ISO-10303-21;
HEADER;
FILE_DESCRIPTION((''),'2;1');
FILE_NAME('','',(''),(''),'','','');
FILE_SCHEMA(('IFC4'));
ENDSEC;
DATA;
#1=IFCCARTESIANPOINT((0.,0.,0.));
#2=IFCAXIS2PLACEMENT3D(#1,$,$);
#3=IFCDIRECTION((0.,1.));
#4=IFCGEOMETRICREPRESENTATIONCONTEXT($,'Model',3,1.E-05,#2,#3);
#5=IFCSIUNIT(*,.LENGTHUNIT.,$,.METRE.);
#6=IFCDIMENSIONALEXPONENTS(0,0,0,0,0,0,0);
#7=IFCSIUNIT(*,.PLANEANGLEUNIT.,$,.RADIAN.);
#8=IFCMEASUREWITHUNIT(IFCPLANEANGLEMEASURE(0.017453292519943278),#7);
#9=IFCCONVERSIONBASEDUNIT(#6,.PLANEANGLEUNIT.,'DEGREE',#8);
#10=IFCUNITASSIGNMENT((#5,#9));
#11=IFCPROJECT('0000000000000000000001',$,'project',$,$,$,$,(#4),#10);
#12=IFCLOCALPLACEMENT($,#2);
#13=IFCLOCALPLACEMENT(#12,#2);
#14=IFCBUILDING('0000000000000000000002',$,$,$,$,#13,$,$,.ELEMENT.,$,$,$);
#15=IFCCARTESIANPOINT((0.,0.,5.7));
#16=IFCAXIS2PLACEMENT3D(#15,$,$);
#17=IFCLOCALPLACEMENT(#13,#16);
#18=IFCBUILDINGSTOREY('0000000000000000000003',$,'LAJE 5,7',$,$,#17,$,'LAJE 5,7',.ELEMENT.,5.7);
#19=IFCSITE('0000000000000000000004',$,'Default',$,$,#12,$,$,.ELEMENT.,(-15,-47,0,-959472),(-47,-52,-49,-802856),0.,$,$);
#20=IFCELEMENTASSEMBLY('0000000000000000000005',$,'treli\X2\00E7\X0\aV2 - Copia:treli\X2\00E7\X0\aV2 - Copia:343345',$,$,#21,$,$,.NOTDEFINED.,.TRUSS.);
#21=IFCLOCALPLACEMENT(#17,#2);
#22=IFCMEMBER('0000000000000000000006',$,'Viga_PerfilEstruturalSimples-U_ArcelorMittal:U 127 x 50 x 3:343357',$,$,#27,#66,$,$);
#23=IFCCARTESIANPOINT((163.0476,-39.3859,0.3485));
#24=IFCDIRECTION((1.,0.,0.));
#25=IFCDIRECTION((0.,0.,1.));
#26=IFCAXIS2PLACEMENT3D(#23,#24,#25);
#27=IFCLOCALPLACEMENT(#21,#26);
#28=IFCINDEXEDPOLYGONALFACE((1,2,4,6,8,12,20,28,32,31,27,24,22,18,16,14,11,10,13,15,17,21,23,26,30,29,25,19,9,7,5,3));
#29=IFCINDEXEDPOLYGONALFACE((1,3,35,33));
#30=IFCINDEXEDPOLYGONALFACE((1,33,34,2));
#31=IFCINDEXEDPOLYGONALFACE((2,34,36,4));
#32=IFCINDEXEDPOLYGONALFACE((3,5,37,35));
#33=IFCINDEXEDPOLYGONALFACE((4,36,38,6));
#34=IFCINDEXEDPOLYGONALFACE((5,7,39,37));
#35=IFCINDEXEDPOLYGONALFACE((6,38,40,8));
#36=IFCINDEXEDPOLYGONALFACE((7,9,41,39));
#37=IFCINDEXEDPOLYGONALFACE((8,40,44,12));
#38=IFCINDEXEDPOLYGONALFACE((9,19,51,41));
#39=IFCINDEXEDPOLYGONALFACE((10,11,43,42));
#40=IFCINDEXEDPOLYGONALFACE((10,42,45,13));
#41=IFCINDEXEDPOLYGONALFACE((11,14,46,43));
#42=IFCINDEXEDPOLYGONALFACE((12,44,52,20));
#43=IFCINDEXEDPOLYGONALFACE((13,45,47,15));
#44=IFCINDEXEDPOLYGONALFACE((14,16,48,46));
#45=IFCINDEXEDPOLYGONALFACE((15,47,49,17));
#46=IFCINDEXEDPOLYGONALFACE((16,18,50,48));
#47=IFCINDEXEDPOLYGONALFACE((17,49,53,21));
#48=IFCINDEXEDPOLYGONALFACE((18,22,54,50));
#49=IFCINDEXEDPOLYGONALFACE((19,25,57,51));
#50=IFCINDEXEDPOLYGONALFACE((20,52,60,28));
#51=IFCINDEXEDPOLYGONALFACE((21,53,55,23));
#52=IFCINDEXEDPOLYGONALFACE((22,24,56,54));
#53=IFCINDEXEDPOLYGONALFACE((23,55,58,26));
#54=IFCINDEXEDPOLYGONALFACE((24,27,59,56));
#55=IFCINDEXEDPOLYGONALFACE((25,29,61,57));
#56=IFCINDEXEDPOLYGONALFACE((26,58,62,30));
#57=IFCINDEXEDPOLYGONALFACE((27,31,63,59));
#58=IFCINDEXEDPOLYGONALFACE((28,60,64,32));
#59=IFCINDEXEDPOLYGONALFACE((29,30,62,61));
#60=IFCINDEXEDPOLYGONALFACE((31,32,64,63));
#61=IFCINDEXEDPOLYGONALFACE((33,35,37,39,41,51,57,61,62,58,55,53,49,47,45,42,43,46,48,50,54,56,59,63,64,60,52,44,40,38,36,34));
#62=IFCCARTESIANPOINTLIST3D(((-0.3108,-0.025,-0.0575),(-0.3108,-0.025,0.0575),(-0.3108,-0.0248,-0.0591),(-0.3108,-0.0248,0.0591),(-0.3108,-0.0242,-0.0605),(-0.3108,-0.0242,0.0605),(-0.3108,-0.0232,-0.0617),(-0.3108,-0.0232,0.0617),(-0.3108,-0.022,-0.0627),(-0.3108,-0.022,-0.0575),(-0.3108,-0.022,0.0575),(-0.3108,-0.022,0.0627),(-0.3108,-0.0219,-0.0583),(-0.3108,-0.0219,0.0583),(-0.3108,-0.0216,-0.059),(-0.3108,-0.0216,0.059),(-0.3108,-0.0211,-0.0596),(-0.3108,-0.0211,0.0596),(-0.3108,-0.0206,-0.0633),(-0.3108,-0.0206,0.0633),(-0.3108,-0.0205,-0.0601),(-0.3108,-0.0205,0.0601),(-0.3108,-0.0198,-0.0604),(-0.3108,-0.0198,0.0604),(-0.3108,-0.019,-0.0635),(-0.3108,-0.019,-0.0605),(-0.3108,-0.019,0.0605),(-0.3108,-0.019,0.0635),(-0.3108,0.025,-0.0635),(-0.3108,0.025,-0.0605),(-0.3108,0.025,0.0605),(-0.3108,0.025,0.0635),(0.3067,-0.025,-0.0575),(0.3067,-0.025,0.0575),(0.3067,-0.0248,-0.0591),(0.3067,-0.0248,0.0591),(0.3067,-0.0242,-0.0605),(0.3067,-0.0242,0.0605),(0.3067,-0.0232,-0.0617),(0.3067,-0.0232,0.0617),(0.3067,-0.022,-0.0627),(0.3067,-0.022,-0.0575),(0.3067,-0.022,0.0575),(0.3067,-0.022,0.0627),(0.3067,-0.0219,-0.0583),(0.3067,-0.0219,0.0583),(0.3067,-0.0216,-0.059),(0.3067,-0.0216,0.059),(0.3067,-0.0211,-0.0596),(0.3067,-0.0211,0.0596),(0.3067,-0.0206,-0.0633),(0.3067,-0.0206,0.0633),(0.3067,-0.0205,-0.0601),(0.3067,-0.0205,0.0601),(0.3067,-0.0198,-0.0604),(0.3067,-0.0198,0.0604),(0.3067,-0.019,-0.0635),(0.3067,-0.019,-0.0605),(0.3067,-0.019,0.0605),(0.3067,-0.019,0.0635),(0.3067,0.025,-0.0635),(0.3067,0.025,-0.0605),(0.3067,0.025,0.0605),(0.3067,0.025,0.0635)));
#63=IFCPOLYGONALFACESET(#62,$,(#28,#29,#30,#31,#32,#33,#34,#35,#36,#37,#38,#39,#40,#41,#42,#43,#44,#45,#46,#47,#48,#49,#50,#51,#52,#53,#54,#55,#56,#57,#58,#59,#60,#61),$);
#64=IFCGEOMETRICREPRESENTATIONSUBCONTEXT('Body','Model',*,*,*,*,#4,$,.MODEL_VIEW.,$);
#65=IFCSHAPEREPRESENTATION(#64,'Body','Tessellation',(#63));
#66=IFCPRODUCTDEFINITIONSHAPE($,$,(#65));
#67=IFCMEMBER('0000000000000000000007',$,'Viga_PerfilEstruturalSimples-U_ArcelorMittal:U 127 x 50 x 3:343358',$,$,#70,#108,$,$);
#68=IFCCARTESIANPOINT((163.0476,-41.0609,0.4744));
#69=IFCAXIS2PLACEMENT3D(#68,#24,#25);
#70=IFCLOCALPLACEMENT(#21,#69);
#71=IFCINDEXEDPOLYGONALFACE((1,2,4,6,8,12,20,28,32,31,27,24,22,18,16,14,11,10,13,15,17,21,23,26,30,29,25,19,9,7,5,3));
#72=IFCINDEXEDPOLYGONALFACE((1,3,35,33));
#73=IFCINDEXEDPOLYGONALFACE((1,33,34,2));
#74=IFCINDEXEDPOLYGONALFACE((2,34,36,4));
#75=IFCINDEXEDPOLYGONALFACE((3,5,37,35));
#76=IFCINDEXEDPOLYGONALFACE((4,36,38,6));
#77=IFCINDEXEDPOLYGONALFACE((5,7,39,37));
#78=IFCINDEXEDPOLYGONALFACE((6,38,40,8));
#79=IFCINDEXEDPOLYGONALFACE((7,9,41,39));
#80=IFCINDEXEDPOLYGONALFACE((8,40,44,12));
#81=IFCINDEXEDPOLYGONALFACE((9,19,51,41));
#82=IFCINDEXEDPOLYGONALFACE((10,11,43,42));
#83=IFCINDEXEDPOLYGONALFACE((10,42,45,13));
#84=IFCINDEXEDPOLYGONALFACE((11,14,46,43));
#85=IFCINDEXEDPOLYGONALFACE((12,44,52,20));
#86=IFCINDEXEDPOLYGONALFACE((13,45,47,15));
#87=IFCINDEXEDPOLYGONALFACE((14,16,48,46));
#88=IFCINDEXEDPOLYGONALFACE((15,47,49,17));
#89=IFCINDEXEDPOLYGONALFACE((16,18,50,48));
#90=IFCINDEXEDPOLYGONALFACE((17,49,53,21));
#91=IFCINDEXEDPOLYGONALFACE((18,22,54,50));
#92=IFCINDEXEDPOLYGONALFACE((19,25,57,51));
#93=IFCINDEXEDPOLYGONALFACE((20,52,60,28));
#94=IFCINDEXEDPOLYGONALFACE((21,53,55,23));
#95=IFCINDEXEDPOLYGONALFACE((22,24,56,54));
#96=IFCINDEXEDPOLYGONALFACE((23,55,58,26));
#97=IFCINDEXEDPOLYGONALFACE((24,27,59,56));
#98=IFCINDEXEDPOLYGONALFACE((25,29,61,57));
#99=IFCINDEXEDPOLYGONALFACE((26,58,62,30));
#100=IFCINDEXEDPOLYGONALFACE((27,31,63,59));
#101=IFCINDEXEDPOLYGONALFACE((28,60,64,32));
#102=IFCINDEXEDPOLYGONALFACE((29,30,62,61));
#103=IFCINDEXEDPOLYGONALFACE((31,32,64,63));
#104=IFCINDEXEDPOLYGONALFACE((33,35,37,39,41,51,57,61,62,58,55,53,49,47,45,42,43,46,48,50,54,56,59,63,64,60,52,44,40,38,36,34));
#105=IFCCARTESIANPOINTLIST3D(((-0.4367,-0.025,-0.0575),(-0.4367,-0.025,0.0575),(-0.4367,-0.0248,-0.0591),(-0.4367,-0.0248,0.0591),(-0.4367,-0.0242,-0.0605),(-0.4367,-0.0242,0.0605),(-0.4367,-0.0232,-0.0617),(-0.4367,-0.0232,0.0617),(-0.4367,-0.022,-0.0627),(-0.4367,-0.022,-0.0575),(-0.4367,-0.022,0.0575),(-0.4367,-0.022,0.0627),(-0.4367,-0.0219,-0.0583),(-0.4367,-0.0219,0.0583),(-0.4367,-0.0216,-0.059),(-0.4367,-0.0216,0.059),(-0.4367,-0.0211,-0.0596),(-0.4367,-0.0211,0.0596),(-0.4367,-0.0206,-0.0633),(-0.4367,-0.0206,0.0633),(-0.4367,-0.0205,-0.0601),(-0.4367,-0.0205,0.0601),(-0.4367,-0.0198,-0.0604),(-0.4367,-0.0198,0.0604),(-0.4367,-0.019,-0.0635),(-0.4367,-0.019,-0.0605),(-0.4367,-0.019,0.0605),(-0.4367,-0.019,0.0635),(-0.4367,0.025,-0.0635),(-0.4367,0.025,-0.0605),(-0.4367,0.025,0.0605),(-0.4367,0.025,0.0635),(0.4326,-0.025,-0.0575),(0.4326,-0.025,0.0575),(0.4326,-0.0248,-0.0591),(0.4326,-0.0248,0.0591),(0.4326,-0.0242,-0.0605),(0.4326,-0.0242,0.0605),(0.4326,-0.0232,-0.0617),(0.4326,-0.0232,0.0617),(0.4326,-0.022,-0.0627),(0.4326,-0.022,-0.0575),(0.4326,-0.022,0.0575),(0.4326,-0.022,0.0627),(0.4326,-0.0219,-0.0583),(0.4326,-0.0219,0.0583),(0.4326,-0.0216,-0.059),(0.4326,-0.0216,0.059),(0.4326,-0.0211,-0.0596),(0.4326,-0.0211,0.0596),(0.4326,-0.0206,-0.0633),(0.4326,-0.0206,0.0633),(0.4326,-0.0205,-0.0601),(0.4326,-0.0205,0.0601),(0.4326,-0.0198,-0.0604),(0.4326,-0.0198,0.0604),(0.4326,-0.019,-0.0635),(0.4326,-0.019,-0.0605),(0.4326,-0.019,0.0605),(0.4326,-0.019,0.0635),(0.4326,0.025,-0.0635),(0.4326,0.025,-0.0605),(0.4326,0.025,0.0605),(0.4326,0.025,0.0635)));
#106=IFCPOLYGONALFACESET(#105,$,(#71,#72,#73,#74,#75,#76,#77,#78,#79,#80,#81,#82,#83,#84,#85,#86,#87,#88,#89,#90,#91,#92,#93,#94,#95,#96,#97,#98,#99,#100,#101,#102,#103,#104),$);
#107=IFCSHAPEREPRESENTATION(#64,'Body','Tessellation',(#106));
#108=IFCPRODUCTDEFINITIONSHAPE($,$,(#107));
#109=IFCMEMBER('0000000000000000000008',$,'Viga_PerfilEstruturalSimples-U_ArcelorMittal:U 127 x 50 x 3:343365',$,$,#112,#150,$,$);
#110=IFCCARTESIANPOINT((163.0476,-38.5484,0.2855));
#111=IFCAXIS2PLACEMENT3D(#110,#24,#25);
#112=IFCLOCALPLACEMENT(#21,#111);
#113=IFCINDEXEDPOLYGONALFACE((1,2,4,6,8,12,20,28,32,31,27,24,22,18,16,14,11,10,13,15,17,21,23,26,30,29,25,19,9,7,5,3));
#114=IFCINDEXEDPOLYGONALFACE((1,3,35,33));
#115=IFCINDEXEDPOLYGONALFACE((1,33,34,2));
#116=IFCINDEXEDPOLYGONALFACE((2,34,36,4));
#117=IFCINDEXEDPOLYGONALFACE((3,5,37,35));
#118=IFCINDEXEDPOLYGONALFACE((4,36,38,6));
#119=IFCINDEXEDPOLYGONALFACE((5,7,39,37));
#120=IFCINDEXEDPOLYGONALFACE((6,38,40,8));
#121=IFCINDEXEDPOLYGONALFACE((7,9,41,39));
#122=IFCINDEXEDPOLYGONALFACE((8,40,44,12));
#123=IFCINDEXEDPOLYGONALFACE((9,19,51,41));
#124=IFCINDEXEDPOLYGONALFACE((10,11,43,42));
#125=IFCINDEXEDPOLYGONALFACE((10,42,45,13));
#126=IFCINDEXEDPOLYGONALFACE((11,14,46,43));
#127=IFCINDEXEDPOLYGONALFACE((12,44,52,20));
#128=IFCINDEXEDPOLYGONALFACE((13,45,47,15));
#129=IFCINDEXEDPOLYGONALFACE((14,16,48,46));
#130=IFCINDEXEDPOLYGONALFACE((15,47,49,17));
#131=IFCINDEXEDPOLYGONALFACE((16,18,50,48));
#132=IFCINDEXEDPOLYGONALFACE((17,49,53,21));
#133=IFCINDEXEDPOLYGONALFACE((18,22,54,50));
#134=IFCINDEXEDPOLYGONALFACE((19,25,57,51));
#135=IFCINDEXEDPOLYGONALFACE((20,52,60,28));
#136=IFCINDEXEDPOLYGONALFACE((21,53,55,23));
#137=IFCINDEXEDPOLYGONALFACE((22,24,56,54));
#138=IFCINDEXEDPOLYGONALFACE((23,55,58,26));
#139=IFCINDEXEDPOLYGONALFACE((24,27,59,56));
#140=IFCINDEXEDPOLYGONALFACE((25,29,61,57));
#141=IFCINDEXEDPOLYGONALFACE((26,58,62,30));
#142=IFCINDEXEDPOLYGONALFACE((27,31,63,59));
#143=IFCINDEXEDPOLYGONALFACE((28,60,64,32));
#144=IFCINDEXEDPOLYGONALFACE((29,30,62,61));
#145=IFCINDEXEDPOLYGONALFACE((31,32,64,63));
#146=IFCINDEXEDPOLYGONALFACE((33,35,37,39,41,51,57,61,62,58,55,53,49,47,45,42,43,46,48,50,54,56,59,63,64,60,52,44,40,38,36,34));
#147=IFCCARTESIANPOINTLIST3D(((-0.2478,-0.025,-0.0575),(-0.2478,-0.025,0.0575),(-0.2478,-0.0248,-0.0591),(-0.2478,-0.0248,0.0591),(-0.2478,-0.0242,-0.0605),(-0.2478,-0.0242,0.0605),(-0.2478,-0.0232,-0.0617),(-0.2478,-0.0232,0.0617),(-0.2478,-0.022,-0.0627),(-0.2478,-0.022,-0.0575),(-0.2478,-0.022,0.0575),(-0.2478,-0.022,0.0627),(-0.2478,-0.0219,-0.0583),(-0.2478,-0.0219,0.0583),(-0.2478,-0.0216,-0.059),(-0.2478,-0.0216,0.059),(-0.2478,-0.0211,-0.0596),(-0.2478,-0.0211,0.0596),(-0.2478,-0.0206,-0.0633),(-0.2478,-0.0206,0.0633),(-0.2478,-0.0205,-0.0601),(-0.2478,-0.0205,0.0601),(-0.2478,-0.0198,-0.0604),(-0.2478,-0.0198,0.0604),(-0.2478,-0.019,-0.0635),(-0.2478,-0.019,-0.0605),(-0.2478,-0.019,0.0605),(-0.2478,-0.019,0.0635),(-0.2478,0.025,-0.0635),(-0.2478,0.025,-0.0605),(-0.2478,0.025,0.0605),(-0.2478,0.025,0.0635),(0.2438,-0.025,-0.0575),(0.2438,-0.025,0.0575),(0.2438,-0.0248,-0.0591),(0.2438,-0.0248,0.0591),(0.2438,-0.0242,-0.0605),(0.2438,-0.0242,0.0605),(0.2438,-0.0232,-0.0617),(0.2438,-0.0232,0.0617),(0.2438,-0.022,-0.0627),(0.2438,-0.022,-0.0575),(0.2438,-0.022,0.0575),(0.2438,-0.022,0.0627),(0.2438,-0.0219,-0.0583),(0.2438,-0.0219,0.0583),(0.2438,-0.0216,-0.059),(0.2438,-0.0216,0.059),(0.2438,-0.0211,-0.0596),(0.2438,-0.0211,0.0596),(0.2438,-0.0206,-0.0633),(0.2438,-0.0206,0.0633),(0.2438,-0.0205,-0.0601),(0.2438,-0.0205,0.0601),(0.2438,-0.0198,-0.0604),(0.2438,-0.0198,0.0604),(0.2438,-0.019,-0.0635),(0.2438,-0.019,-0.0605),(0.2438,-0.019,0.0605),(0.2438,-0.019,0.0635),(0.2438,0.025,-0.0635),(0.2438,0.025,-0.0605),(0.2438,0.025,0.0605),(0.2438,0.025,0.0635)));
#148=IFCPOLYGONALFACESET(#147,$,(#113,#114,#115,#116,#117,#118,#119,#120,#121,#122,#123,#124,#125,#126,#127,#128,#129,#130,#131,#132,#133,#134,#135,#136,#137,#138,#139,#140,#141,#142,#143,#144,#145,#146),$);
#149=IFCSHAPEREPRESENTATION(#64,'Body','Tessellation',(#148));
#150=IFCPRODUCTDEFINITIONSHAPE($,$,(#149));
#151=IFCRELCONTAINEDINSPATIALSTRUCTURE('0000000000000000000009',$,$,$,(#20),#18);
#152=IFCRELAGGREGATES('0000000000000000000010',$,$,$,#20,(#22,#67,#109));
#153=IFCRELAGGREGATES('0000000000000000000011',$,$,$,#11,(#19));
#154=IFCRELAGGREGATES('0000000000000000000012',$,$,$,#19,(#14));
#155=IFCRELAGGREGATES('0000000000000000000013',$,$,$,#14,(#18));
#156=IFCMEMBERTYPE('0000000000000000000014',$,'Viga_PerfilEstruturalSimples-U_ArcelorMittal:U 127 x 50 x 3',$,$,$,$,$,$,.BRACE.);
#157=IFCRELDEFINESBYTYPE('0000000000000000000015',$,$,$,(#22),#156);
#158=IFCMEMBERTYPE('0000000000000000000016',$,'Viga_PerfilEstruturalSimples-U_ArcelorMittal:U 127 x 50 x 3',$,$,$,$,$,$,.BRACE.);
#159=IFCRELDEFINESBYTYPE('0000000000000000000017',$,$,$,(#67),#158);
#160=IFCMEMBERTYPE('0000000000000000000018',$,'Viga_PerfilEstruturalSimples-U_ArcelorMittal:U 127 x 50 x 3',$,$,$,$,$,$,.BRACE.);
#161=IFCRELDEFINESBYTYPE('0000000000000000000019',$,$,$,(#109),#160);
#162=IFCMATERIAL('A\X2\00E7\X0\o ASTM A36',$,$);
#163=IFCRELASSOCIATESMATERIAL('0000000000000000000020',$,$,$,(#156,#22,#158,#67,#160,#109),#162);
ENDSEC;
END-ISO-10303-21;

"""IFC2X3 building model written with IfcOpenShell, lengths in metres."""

from ifc_helpers import new_model, entity, si_unit, converted_unit, direction, frame, frame_2d, origin, place, context, subcontext, project, spatial, polyline, circle_curve, parameter, trimmed, segment, composite_curve, outline, extrude, source, transform, mapped, material, type_object, type_shapes, element, aggregate, save


model = new_model("IFC2X3")

# Units and contexts
model_context = context("Model", 3, precision=1e-05, world=origin(), true_north=direction((0.0, 1.0)))
body_context = subcontext(model_context, "Body", "Model", "MODEL_VIEW")
ifc_project = project(units=[si_unit("LENGTHUNIT", "METRE"), converted_unit("PLANEANGLEUNIT", "DEGREE", entity("IfcPlaneAngleMeasure", 0.017453292519943278), si_unit("PLANEANGLEUNIT", "RADIAN"), dimensions=[0, 0, 0, 0, 0, 0, 0])], contexts=[model_context])

# Site, building, storey
site_placement = place(None, origin())
site = spatial("IfcSite", under=ifc_project, at=site_placement, Name="Default", CompositionType="ELEMENT", RefLatitude=(-15, -47, 0, -959472), RefLongitude=(-47, -52, -49, -802856), RefElevation=0.0)
building_placement = place(site_placement, origin())
building = spatial("IfcBuilding", under=site, at=building_placement, CompositionType="ELEMENT")
storey_placement = place(building_placement, frame((0.0, 0.0, 5.7)))
storey = spatial("IfcBuildingStorey", under=building, at=storey_placement, Name="LAJE 5,7", LongName="LAJE 5,7", CompositionType="ELEMENT", Elevation=5.7)

# Element assembly
assembly_1_placement = place(storey_placement, origin())
assembly_1 = element("IfcElementAssembly", 1, at=assembly_1_placement, inside=storey, Name="treliçaV2 - Copia:treliçaV2 - Copia:343345", AssemblyPlace="NOTDEFINED", PredefinedType="TRUSS")
ifc_material = material(Name="Aço ASTM A36")

# Members
member_type_1 = type_object("IfcMemberType", Name="Viga_PerfilEstruturalSimples-U_ArcelorMittal:U 127 x 50 x 3", PredefinedType="BRACE", material=ifc_material)
shared_shape_1 = source(origin(), body_context, "Body", "SweptSolid", [
    extrude(outline(composite_curve([segment(polyline([(-0.0575, -0.0192), (0.0575, -0.0192)]), True, "CONTINUOUS"), segment(trimmed(circle_curve(frame_2d((0.0575, -0.0132), x_axis=(0.0, 1.0)), 0.006), [parameter(180.0)], [parameter(270.0)], True, "PARAMETER"), True, "CONTINUOUS"), segment(polyline([(0.0635, -0.0132), (0.0635, 0.0308)]), True, "CONTINUOUS"), segment(polyline([(0.0635, 0.0308), (0.0605, 0.0308)]), True, "CONTINUOUS"), segment(polyline([(0.0605, 0.0308), (0.0605, -0.0132)]), True, "CONTINUOUS"), segment(trimmed(circle_curve(frame_2d((0.0575, -0.0132), x_axis=(0.0, 1.0)), 0.003), [parameter(180.0)], [parameter(270.0)], True, "PARAMETER"), False, "CONTINUOUS"), segment(polyline([(0.0575, -0.0162), (-0.0575, -0.0162)]), True, "CONTINUOUS"), segment(trimmed(circle_curve(frame_2d((-0.0575, -0.0132), x_axis=(0.0, 1.0)), 0.003), [parameter(90.0)], [parameter(180.0)], True, "PARAMETER"), False, "CONTINUOUS"), segment(polyline([(-0.0605, -0.0132), (-0.0605, 0.0308)]), True, "CONTINUOUS"), segment(polyline([(-0.0605, 0.0308), (-0.0635, 0.0308)]), True, "CONTINUOUS"), segment(polyline([(-0.0635, 0.0308), (-0.0635, -0.0132)]), True, "CONTINUOUS"), segment(trimmed(circle_curve(frame_2d((-0.0575, -0.0132), x_axis=(0.0, 1.0)), 0.006), [parameter(90.0)], [parameter(180.0)], True, "PARAMETER"), True, "CONTINUOUS")], self_intersect=False)), frame((-0.3108, -0.0058, 0.0), z_axis=(1.0, 0.0, 0.0), x_axis=(0.0, 0.0, -1.0)), (0.0, 0.0, 1.0), 0.6175),
])
type_shapes(member_type_1, [shared_shape_1])
member_1_placement = place(assembly_1_placement, frame((163.0476, -39.3859, 0.3485), z_axis=(1.0, 0.0, 0.0), x_axis=(0.0, 0.0, 1.0)))
member_1 = element("IfcMember", 2, at=member_1_placement, type_object=member_type_1, material=ifc_material, Name="Viga_PerfilEstruturalSimples-U_ArcelorMittal:U 127 x 50 x 3:343357", context=body_context, shape_type="MappedRepresentation", body=[
    mapped(shared_shape_1, transform((0.0, 0.0, 0.0), scale=1.0)),
])
member_type_2 = type_object("IfcMemberType", Name="Viga_PerfilEstruturalSimples-U_ArcelorMittal:U 127 x 50 x 3", PredefinedType="BRACE", material=ifc_material)
shared_shape_2 = source(origin(), body_context, "Body", "SweptSolid", [
    extrude(outline(composite_curve([segment(polyline([(-0.0575, -0.0192), (0.0575, -0.0192)]), True, "CONTINUOUS"), segment(trimmed(circle_curve(frame_2d((0.0575, -0.0132), x_axis=(0.0, 1.0)), 0.006), [parameter(180.0)], [parameter(270.0)], True, "PARAMETER"), True, "CONTINUOUS"), segment(polyline([(0.0635, -0.0132), (0.0635, 0.0308)]), True, "CONTINUOUS"), segment(polyline([(0.0635, 0.0308), (0.0605, 0.0308)]), True, "CONTINUOUS"), segment(polyline([(0.0605, 0.0308), (0.0605, -0.0132)]), True, "CONTINUOUS"), segment(trimmed(circle_curve(frame_2d((0.0575, -0.0132), x_axis=(0.0, 1.0)), 0.003), [parameter(180.0)], [parameter(270.0)], True, "PARAMETER"), False, "CONTINUOUS"), segment(polyline([(0.0575, -0.0162), (-0.0575, -0.0162)]), True, "CONTINUOUS"), segment(trimmed(circle_curve(frame_2d((-0.0575, -0.0132), x_axis=(0.0, 1.0)), 0.003), [parameter(90.0)], [parameter(180.0)], True, "PARAMETER"), False, "CONTINUOUS"), segment(polyline([(-0.0605, -0.0132), (-0.0605, 0.0308)]), True, "CONTINUOUS"), segment(polyline([(-0.0605, 0.0308), (-0.0635, 0.0308)]), True, "CONTINUOUS"), segment(polyline([(-0.0635, 0.0308), (-0.0635, -0.0132)]), True, "CONTINUOUS"), segment(trimmed(circle_curve(frame_2d((-0.0575, -0.0132), x_axis=(0.0, 1.0)), 0.006), [parameter(90.0)], [parameter(180.0)], True, "PARAMETER"), True, "CONTINUOUS")], self_intersect=False)), frame((-0.4367, -0.0058, 0.0), z_axis=(1.0, 0.0, 0.0), x_axis=(0.0, 0.0, -1.0)), (0.0, 0.0, 1.0), 0.8693),
])
type_shapes(member_type_2, [shared_shape_2])
member_2_placement = place(assembly_1_placement, frame((163.0476, -41.0609, 0.4744), z_axis=(1.0, 0.0, 0.0), x_axis=(0.0, 0.0, 1.0)))
member_2 = element("IfcMember", 3, at=member_2_placement, type_object=member_type_2, material=ifc_material, Name="Viga_PerfilEstruturalSimples-U_ArcelorMittal:U 127 x 50 x 3:343358", context=body_context, shape_type="MappedRepresentation", body=[
    mapped(shared_shape_2, transform((0.0, 0.0, 0.0), scale=1.0)),
])
member_type_3 = type_object("IfcMemberType", Name="Viga_PerfilEstruturalSimples-U_ArcelorMittal:U 127 x 50 x 3", PredefinedType="BRACE", material=ifc_material)
shared_shape_3 = source(origin(), body_context, "Body", "SweptSolid", [
    extrude(outline(composite_curve([segment(polyline([(-0.0575, -0.0192), (0.0575, -0.0192)]), True, "CONTINUOUS"), segment(trimmed(circle_curve(frame_2d((0.0575, -0.0132), x_axis=(0.0, 1.0)), 0.006), [parameter(180.0)], [parameter(270.0)], True, "PARAMETER"), True, "CONTINUOUS"), segment(polyline([(0.0635, -0.0132), (0.0635, 0.0308)]), True, "CONTINUOUS"), segment(polyline([(0.0635, 0.0308), (0.0605, 0.0308)]), True, "CONTINUOUS"), segment(polyline([(0.0605, 0.0308), (0.0605, -0.0132)]), True, "CONTINUOUS"), segment(trimmed(circle_curve(frame_2d((0.0575, -0.0132), x_axis=(0.0, 1.0)), 0.003), [parameter(180.0)], [parameter(270.0)], True, "PARAMETER"), False, "CONTINUOUS"), segment(polyline([(0.0575, -0.0162), (-0.0575, -0.0162)]), True, "CONTINUOUS"), segment(trimmed(circle_curve(frame_2d((-0.0575, -0.0132), x_axis=(0.0, 1.0)), 0.003), [parameter(90.0)], [parameter(180.0)], True, "PARAMETER"), False, "CONTINUOUS"), segment(polyline([(-0.0605, -0.0132), (-0.0605, 0.0308)]), True, "CONTINUOUS"), segment(polyline([(-0.0605, 0.0308), (-0.0635, 0.0308)]), True, "CONTINUOUS"), segment(polyline([(-0.0635, 0.0308), (-0.0635, -0.0132)]), True, "CONTINUOUS"), segment(trimmed(circle_curve(frame_2d((-0.0575, -0.0132), x_axis=(0.0, 1.0)), 0.006), [parameter(90.0)], [parameter(180.0)], True, "PARAMETER"), True, "CONTINUOUS")], self_intersect=False)), frame((-0.2478, -0.0058, 0.0), z_axis=(1.0, 0.0, 0.0), x_axis=(0.0, 0.0, -1.0)), (0.0, 0.0, 1.0), 0.4916),
])
type_shapes(member_type_3, [shared_shape_3])
member_3_placement = place(assembly_1_placement, frame((163.0476, -38.5484, 0.2855), z_axis=(1.0, 0.0, 0.0), x_axis=(0.0, 0.0, 1.0)))
member_3 = element("IfcMember", 4, at=member_3_placement, type_object=member_type_3, material=ifc_material, Name="Viga_PerfilEstruturalSimples-U_ArcelorMittal:U 127 x 50 x 3:343365", context=body_context, shape_type="MappedRepresentation", body=[
    mapped(shared_shape_3, transform((0.0, 0.0, 0.0), scale=1.0)),
])
aggregate(assembly_1, [member_1, member_2, member_3])

save(model, "model.ifc")
